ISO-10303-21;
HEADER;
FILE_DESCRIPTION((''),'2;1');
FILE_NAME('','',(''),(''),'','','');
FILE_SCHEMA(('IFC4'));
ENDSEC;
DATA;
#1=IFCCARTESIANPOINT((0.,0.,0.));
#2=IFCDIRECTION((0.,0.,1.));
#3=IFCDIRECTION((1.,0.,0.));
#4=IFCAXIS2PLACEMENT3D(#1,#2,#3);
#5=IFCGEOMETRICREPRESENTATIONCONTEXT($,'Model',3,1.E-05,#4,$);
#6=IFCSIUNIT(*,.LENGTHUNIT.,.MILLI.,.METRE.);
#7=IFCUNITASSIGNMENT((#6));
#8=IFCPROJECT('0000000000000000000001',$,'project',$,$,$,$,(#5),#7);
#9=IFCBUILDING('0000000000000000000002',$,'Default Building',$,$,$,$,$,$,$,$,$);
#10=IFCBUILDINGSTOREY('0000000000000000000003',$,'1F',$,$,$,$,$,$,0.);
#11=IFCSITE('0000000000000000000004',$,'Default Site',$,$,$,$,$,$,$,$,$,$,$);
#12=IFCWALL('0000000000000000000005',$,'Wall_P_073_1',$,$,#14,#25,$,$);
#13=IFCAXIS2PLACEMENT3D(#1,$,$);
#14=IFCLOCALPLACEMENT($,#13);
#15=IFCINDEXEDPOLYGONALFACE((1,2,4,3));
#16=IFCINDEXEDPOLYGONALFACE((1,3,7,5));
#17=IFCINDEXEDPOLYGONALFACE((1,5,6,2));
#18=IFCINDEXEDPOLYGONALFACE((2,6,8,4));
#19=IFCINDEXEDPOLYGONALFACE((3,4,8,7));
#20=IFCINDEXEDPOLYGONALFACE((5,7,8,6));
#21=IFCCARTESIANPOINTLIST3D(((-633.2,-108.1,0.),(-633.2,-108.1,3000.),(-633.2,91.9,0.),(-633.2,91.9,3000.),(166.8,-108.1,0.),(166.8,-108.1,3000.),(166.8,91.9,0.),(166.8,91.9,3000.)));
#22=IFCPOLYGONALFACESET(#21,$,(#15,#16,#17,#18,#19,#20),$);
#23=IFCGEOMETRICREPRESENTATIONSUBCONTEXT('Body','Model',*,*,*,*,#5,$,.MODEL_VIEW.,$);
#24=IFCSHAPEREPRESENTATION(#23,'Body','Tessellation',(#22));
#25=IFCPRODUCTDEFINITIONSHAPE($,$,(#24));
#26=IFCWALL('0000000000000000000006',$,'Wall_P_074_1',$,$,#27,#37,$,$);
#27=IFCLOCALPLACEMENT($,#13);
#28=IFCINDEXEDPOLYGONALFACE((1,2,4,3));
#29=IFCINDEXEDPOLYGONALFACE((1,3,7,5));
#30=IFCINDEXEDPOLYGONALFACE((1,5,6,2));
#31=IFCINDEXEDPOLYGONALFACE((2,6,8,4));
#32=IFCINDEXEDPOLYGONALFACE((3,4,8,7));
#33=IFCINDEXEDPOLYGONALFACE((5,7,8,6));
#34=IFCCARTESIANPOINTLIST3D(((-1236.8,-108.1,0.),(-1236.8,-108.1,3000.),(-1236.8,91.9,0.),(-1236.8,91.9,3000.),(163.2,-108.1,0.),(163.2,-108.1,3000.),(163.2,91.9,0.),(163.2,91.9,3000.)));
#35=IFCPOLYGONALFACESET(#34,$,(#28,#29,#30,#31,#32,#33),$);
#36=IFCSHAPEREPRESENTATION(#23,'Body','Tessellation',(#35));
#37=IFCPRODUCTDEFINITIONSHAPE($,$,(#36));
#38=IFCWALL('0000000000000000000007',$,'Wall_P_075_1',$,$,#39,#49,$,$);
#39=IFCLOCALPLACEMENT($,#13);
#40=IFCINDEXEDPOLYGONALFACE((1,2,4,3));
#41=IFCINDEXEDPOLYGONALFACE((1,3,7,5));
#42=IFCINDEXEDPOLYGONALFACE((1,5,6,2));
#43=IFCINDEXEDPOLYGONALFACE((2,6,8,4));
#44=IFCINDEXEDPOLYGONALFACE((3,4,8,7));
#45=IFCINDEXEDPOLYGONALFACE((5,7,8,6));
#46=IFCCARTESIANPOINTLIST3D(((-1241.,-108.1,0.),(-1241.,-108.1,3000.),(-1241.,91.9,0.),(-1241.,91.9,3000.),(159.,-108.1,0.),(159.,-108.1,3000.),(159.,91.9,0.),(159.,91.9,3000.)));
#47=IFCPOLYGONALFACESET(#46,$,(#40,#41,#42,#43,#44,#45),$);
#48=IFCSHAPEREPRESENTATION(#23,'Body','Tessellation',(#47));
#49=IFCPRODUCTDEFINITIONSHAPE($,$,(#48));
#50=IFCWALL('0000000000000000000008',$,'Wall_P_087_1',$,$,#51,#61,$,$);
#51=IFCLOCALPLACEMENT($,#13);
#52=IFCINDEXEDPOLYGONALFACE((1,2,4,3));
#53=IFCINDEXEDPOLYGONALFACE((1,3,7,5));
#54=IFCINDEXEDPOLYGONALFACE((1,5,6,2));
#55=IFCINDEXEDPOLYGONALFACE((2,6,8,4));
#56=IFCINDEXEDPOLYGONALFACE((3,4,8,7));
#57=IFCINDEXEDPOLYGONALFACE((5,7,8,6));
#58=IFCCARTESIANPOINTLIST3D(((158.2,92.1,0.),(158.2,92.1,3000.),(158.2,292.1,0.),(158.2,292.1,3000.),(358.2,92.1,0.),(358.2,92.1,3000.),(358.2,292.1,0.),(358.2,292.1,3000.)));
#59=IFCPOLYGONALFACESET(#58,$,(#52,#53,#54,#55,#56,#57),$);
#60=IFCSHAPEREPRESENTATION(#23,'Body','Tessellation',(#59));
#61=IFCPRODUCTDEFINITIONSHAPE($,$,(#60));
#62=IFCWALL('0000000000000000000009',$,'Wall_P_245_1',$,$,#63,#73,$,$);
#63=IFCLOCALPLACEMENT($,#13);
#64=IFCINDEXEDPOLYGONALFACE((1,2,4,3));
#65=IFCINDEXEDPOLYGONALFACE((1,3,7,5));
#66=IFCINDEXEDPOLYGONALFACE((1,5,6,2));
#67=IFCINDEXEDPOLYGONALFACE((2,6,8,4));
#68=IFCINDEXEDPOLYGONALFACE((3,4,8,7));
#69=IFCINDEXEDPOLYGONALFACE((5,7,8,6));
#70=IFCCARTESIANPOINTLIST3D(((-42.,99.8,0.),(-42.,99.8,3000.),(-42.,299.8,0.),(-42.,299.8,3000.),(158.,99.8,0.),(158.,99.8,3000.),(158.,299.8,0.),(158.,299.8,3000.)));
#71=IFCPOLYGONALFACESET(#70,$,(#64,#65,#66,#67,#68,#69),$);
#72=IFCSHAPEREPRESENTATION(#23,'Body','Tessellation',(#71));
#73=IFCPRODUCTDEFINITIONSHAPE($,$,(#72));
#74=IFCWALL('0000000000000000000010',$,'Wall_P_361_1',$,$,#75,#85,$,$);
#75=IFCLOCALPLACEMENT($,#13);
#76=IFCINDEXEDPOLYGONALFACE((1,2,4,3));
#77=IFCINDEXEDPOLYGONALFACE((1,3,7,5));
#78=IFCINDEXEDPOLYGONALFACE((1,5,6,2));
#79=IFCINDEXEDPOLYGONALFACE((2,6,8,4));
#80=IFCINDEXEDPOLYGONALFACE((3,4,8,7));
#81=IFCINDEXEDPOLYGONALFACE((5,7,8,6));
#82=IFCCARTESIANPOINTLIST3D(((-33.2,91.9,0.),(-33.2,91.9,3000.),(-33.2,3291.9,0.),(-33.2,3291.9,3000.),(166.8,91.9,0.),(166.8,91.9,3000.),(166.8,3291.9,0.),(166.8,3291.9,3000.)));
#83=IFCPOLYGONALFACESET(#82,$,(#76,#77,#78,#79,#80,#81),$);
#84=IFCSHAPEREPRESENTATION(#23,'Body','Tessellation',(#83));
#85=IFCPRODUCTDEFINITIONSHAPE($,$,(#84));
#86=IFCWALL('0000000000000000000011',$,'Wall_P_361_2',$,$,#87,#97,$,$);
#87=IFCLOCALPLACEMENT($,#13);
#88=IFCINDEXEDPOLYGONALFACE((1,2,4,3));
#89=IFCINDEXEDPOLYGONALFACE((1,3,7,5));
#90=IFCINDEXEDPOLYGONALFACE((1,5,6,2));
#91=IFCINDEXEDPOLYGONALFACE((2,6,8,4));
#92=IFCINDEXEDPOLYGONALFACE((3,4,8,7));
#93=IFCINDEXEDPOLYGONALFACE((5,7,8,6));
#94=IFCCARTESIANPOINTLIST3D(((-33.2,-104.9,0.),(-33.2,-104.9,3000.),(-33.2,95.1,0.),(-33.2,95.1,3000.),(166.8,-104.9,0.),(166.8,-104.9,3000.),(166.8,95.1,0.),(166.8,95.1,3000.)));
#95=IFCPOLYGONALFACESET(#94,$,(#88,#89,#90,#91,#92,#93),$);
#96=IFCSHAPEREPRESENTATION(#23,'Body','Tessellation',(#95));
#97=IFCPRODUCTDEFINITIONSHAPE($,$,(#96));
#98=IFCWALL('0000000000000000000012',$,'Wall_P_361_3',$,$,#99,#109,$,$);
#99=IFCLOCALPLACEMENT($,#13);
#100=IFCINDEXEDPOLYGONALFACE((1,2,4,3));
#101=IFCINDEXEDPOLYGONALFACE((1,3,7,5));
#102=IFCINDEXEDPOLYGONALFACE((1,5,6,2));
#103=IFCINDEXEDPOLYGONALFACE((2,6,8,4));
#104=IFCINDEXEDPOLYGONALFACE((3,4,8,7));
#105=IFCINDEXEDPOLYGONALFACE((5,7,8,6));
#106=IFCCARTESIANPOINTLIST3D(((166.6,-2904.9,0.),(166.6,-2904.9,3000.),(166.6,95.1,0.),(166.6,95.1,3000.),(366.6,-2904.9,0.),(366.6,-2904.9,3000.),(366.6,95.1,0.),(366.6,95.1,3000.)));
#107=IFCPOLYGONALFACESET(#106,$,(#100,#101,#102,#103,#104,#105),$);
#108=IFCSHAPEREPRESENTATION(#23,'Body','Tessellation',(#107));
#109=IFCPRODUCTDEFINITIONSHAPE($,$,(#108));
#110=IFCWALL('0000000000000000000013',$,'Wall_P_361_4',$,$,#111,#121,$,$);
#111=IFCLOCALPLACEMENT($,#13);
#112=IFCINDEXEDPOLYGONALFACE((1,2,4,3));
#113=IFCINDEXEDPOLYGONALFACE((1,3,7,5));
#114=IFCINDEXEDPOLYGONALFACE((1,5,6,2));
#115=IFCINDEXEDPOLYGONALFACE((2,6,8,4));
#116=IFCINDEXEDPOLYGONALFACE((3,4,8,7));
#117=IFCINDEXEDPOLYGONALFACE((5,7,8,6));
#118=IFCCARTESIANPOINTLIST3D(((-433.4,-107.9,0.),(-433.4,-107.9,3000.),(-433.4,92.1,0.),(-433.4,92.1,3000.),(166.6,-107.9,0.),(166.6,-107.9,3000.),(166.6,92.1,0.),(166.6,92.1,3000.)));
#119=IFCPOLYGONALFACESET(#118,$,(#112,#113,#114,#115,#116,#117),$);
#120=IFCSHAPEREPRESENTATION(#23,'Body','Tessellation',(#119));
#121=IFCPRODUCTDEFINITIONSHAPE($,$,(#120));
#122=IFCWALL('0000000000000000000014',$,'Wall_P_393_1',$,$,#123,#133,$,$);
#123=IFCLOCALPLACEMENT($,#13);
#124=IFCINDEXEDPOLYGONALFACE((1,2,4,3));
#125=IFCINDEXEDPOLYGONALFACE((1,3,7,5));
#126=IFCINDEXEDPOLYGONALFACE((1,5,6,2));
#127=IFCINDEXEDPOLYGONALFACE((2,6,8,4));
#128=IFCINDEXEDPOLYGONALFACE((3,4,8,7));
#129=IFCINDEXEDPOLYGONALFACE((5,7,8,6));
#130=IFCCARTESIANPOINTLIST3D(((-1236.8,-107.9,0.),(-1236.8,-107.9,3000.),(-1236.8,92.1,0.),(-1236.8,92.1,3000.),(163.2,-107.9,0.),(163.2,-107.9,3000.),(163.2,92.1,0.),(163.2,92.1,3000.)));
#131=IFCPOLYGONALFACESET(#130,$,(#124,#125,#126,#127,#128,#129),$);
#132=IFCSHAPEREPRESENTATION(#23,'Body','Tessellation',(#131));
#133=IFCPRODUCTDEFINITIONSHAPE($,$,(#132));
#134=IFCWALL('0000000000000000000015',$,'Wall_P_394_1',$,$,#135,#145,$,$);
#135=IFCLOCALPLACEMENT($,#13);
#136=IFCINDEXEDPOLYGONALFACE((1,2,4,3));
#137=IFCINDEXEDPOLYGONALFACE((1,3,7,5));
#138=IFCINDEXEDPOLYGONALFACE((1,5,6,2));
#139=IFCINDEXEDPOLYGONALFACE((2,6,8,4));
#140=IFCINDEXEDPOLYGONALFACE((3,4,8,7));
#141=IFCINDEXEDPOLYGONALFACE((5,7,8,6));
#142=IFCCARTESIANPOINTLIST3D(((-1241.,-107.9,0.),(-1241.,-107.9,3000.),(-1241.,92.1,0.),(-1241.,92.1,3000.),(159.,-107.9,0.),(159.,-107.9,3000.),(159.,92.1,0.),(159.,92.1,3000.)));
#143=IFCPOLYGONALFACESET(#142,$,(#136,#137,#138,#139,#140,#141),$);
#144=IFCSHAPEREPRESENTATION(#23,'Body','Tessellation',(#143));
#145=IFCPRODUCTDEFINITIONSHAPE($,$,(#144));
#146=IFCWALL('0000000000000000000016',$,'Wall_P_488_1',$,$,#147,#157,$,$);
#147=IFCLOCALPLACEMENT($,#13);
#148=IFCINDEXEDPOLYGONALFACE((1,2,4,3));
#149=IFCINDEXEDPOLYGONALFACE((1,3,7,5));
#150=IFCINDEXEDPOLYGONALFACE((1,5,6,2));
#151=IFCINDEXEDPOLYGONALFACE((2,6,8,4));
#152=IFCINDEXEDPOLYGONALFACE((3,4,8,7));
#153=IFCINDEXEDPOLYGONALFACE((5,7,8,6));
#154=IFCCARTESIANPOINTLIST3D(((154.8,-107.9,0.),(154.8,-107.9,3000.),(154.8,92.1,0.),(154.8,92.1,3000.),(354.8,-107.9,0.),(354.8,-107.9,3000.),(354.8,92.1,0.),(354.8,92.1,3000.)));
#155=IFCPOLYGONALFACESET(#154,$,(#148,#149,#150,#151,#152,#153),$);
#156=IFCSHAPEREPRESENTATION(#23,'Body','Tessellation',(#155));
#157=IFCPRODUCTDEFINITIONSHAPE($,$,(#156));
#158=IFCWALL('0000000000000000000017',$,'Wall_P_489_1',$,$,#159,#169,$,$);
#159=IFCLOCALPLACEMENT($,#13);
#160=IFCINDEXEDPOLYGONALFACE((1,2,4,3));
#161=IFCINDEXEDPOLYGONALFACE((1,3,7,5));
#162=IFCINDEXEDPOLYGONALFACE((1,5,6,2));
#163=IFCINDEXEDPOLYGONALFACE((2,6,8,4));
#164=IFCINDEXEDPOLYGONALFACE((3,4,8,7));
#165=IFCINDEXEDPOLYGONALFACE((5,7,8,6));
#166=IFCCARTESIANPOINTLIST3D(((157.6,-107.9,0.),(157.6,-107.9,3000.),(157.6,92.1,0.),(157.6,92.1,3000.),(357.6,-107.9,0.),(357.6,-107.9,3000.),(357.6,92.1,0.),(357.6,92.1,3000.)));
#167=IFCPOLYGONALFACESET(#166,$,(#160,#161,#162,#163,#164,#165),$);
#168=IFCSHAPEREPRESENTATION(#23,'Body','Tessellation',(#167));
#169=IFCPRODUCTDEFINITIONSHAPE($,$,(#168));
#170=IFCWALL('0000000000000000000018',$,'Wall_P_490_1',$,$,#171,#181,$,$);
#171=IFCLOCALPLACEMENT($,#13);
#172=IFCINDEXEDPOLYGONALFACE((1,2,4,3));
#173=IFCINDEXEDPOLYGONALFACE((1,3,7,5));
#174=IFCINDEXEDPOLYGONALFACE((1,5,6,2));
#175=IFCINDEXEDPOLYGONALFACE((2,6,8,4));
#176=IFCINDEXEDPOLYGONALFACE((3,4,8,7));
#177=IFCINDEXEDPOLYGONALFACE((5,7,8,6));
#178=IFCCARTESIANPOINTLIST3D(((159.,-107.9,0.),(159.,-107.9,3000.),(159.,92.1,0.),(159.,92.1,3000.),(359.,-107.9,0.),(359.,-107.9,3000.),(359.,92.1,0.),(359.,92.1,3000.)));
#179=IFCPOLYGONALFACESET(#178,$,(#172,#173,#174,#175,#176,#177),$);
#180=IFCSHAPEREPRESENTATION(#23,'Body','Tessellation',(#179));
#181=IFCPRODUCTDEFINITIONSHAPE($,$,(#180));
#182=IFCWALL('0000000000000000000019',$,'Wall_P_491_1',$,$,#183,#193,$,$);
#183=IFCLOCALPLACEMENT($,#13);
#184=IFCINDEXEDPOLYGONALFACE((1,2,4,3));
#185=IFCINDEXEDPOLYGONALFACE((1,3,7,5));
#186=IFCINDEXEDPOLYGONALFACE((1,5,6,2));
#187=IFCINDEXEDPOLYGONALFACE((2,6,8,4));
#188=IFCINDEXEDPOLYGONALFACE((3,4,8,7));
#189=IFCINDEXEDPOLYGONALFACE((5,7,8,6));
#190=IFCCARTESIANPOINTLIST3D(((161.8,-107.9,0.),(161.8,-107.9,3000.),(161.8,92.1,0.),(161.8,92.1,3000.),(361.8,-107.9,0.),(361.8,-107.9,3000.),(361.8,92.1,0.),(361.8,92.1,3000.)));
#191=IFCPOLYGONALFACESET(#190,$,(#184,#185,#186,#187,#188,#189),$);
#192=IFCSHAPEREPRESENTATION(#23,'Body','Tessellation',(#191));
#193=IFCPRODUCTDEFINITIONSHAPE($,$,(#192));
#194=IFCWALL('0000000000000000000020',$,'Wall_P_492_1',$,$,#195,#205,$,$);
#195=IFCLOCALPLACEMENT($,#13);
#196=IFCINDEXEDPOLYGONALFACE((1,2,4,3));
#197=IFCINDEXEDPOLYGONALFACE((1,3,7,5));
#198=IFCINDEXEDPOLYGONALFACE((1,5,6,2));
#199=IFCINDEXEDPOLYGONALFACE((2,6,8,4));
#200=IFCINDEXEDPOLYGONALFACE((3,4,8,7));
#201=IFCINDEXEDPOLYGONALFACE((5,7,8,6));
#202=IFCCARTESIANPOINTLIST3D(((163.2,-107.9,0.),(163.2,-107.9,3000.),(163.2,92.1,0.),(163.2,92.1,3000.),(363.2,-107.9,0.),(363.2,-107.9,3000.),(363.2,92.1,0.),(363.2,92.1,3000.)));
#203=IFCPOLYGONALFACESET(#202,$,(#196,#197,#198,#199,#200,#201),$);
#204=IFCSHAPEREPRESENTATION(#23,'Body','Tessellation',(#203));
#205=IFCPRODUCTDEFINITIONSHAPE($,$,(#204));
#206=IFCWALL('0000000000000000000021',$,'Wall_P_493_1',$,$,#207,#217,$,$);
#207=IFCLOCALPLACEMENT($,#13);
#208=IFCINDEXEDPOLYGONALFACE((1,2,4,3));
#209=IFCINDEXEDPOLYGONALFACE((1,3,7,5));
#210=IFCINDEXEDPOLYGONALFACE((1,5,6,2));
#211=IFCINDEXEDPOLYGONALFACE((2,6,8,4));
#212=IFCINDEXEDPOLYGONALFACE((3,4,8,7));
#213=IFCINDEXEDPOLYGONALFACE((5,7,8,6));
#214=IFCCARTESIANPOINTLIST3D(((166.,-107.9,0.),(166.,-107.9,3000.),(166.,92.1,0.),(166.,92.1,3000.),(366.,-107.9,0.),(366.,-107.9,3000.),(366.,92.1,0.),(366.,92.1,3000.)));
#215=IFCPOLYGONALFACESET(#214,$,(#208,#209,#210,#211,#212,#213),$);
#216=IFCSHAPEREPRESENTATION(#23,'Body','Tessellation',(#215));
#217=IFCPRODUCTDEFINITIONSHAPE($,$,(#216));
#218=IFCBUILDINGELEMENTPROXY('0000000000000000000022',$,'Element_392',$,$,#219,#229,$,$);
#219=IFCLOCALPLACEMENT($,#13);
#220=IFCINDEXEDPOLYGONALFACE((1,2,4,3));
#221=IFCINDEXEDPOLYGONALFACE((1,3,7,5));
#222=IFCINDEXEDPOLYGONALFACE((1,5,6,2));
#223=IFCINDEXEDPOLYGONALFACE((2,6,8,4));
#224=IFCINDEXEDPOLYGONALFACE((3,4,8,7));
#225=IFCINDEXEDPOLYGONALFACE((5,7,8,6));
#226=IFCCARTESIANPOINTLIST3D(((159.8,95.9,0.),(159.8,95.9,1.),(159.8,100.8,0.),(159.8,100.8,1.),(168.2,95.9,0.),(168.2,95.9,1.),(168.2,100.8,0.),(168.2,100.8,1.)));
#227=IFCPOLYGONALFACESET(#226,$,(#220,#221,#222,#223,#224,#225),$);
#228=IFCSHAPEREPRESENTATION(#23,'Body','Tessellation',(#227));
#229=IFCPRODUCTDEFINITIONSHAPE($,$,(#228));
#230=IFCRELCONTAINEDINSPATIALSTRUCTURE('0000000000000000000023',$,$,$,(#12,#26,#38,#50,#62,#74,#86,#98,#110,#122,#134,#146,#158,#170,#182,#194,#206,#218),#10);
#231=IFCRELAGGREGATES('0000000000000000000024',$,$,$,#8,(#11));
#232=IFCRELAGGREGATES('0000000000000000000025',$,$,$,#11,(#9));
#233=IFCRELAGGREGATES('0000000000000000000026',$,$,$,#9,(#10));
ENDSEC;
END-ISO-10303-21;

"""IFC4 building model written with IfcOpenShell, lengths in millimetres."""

from ifc_helpers import new_model, si_unit, frame, origin, origin_with_axes, place, context, subcontext, project, spatial, indexed_curve, rectangle, outline, extrude, element, save


model = new_model("IFC4")

# Units and contexts
model_context = context("Model", 3, precision=1e-05, world=origin_with_axes())
body_context = subcontext(model_context, "Body", "Model", "MODEL_VIEW")
ifc_project = project(units=[si_unit("LENGTHUNIT", "METRE", prefix="MILLI")], contexts=[model_context])

# Site, building, storey
site = spatial("IfcSite", under=ifc_project, Name="Default Site")
building = spatial("IfcBuilding", under=site, Name="Default Building")
storey = spatial("IfcBuildingStorey", under=building, Name="1F", Elevation=0.0)

# Walls
wall_1_placement = place(None, frame((166.8, 91.9, 0.0), z_axis=(0.0, 0.0, 1.0), x_axis=(-1.0, 0.0, 0.0)))
element("IfcWall", 1, at=wall_1_placement, inside=storey, Name="Wall_P_073_1", context=body_context, shape_type="SweptSolid", body=[
    extrude(outline(indexed_curve([(0.0, 0.0), (0.0, 200.0), (800.0, 200.0), (800.0, 0.0), (0.0, 0.0)], self_intersect=False)), origin_with_axes(), (0.0, 0.0, 1.0), 3000.0),
])
for number, where, z_axis, x_axis, name in (
    (2, (163.2, 91.9, 0.0), (0.0, 0.0, 1.0), (-1.0, 0.0, 0.0), "Wall_P_074_1"),
    (3, (159.0, 91.9, 0.0), (0.0, 0.0, 1.0), (-1.0, 0.0, 0.0), "Wall_P_075_1"),
):
    element("IfcWall", number, at=place(None, frame(where, z_axis=z_axis, x_axis=x_axis)), inside=storey, Name=name, context=body_context, shape_type="SweptSolid", body=[
        extrude(outline(indexed_curve([(0.0, 0.0), (0.0, 200.0), (1400.0, 200.0), (1400.0, 0.0), (0.0, 0.0)], self_intersect=False)), origin_with_axes(), (0.0, 0.0, 1.0), 3000.0),
    ])
wall_2_placement = place(None, frame((158.2, 92.1, 0.0), z_axis=(0.0, 0.0, 1.0), x_axis=(1.0, 0.0, 0.0)))
element("IfcWall", 4, at=wall_2_placement, inside=storey, Name="Wall_P_087_1", context=body_context, shape_type="SweptSolid", body=[
    extrude(outline(indexed_curve([(0.0, 0.0), (0.0, 200.0), (200.0, 200.0), (200.0, 0.0), (0.0, 0.0)], self_intersect=False)), origin_with_axes(), (0.0, 0.0, 1.0), 3000.0),
])
wall_3_placement = place(None, frame((158.0, 99.8, 0.0), z_axis=(0.0, 0.0, 1.0), x_axis=(0.0, 1.0, 0.0)))
element("IfcWall", 5, at=wall_3_placement, inside=storey, Name="Wall_P_245_1", context=body_context, shape_type="SweptSolid", body=[
    extrude(outline(indexed_curve([(0.0, 0.0), (0.0, 200.0), (200.0, 200.0), (200.0, 0.0), (0.0, 0.0)], self_intersect=False)), origin_with_axes(), (0.0, 0.0, 1.0), 3000.0),
])
wall_4_placement = place(None, frame((166.8, 91.9, 0.0), z_axis=(0.0, 0.0, 1.0), x_axis=(0.0, 1.0, 0.0)))
element("IfcWall", 6, at=wall_4_placement, inside=storey, Name="Wall_P_361_1", context=body_context, shape_type="SweptSolid", body=[
    extrude(outline(indexed_curve([(0.0, 0.0), (0.0, 200.0), (3200.0, 200.0), (3200.0, 0.0), (0.0, 0.0)], self_intersect=False)), origin_with_axes(), (0.0, 0.0, 1.0), 3000.0),
])
wall_5_placement = place(None, frame((166.8, 95.1, 0.0), z_axis=(0.0, 0.0, 1.0), x_axis=(-1.0, 0.0, 0.0)))
element("IfcWall", 7, at=wall_5_placement, inside=storey, Name="Wall_P_361_2", context=body_context, shape_type="SweptSolid", body=[
    extrude(outline(indexed_curve([(0.0, 0.0), (0.0, 200.0), (200.0, 200.0), (200.0, 0.0), (0.0, 0.0)], self_intersect=False)), origin_with_axes(), (0.0, 0.0, 1.0), 3000.0),
])
wall_6_placement = place(None, frame((166.6, 95.1, 0.0), z_axis=(0.0, 0.0, 1.0), x_axis=(0.0, -1.0, 0.0)))
element("IfcWall", 8, at=wall_6_placement, inside=storey, Name="Wall_P_361_3", context=body_context, shape_type="SweptSolid", body=[
    extrude(outline(indexed_curve([(0.0, 0.0), (0.0, 200.0), (3000.0, 200.0), (3000.0, 0.0), (0.0, 0.0)], self_intersect=False)), origin_with_axes(), (0.0, 0.0, 1.0), 3000.0),
])
wall_7_placement = place(None, frame((166.6, 92.1, 0.0), z_axis=(0.0, 0.0, 1.0), x_axis=(-1.0, 0.0, 0.0)))
element("IfcWall", 9, at=wall_7_placement, inside=storey, Name="Wall_P_361_4", context=body_context, shape_type="SweptSolid", body=[
    extrude(outline(indexed_curve([(0.0, 0.0), (0.0, 200.0), (600.0, 200.0), (600.0, 0.0), (0.0, 0.0)], self_intersect=False)), origin_with_axes(), (0.0, 0.0, 1.0), 3000.0),
])
for number, where, z_axis, x_axis, name in (
    (10, (163.2, 92.1, 0.0), (0.0, 0.0, 1.0), (-1.0, 0.0, 0.0), "Wall_P_393_1"),
    (11, (159.0, 92.1, 0.0), (0.0, 0.0, 1.0), (-1.0, 0.0, 0.0), "Wall_P_394_1"),
):
    element("IfcWall", number, at=place(None, frame(where, z_axis=z_axis, x_axis=x_axis)), inside=storey, Name=name, context=body_context, shape_type="SweptSolid", body=[
        extrude(outline(indexed_curve([(0.0, 0.0), (0.0, 200.0), (1400.0, 200.0), (1400.0, 0.0), (0.0, 0.0)], self_intersect=False)), origin_with_axes(), (0.0, 0.0, 1.0), 3000.0),
    ])
for number, where, z_axis, x_axis, name in (
    (12, (154.8, 92.1, 0.0), (0.0, 0.0, 1.0), (0.0, -1.0, 0.0), "Wall_P_488_1"),
    (13, (157.6, 92.1, 0.0), (0.0, 0.0, 1.0), (0.0, -1.0, 0.0), "Wall_P_489_1"),
    (14, (159.0, 92.1, 0.0), (0.0, 0.0, 1.0), (0.0, -1.0, 0.0), "Wall_P_490_1"),
    (15, (161.8, 92.1, 0.0), (0.0, 0.0, 1.0), (0.0, -1.0, 0.0), "Wall_P_491_1"),
    (16, (163.2, 92.1, 0.0), (0.0, 0.0, 1.0), (0.0, -1.0, 0.0), "Wall_P_492_1"),
    (17, (166.0, 92.1, 0.0), (0.0, 0.0, 1.0), (0.0, -1.0, 0.0), "Wall_P_493_1"),
):
    element("IfcWall", number, at=place(None, frame(where, z_axis=z_axis, x_axis=x_axis)), inside=storey, Name=name, context=body_context, shape_type="SweptSolid", body=[
        extrude(outline(indexed_curve([(0.0, 0.0), (0.0, 200.0), (200.0, 200.0), (200.0, 0.0), (0.0, 0.0)], self_intersect=False)), origin_with_axes(), (0.0, 0.0, 1.0), 3000.0),
    ])

# Building element proxy
proxy_1_placement = place(None, frame((164.0, 98.4, 0.0), z_axis=(0.0, 0.0, 1.0), x_axis=(1.0, 0.0, 0.0)))
element("IfcBuildingElementProxy", 18, at=proxy_1_placement, inside=storey, Name="Element_392", context=body_context, shape_type="SweptSolid", body=[
    extrude(rectangle(XDim=8.4, YDim=4.9), origin(), (0.0, 0.0, 1.0), 1.0),
])

save(model, "model.ifc")
